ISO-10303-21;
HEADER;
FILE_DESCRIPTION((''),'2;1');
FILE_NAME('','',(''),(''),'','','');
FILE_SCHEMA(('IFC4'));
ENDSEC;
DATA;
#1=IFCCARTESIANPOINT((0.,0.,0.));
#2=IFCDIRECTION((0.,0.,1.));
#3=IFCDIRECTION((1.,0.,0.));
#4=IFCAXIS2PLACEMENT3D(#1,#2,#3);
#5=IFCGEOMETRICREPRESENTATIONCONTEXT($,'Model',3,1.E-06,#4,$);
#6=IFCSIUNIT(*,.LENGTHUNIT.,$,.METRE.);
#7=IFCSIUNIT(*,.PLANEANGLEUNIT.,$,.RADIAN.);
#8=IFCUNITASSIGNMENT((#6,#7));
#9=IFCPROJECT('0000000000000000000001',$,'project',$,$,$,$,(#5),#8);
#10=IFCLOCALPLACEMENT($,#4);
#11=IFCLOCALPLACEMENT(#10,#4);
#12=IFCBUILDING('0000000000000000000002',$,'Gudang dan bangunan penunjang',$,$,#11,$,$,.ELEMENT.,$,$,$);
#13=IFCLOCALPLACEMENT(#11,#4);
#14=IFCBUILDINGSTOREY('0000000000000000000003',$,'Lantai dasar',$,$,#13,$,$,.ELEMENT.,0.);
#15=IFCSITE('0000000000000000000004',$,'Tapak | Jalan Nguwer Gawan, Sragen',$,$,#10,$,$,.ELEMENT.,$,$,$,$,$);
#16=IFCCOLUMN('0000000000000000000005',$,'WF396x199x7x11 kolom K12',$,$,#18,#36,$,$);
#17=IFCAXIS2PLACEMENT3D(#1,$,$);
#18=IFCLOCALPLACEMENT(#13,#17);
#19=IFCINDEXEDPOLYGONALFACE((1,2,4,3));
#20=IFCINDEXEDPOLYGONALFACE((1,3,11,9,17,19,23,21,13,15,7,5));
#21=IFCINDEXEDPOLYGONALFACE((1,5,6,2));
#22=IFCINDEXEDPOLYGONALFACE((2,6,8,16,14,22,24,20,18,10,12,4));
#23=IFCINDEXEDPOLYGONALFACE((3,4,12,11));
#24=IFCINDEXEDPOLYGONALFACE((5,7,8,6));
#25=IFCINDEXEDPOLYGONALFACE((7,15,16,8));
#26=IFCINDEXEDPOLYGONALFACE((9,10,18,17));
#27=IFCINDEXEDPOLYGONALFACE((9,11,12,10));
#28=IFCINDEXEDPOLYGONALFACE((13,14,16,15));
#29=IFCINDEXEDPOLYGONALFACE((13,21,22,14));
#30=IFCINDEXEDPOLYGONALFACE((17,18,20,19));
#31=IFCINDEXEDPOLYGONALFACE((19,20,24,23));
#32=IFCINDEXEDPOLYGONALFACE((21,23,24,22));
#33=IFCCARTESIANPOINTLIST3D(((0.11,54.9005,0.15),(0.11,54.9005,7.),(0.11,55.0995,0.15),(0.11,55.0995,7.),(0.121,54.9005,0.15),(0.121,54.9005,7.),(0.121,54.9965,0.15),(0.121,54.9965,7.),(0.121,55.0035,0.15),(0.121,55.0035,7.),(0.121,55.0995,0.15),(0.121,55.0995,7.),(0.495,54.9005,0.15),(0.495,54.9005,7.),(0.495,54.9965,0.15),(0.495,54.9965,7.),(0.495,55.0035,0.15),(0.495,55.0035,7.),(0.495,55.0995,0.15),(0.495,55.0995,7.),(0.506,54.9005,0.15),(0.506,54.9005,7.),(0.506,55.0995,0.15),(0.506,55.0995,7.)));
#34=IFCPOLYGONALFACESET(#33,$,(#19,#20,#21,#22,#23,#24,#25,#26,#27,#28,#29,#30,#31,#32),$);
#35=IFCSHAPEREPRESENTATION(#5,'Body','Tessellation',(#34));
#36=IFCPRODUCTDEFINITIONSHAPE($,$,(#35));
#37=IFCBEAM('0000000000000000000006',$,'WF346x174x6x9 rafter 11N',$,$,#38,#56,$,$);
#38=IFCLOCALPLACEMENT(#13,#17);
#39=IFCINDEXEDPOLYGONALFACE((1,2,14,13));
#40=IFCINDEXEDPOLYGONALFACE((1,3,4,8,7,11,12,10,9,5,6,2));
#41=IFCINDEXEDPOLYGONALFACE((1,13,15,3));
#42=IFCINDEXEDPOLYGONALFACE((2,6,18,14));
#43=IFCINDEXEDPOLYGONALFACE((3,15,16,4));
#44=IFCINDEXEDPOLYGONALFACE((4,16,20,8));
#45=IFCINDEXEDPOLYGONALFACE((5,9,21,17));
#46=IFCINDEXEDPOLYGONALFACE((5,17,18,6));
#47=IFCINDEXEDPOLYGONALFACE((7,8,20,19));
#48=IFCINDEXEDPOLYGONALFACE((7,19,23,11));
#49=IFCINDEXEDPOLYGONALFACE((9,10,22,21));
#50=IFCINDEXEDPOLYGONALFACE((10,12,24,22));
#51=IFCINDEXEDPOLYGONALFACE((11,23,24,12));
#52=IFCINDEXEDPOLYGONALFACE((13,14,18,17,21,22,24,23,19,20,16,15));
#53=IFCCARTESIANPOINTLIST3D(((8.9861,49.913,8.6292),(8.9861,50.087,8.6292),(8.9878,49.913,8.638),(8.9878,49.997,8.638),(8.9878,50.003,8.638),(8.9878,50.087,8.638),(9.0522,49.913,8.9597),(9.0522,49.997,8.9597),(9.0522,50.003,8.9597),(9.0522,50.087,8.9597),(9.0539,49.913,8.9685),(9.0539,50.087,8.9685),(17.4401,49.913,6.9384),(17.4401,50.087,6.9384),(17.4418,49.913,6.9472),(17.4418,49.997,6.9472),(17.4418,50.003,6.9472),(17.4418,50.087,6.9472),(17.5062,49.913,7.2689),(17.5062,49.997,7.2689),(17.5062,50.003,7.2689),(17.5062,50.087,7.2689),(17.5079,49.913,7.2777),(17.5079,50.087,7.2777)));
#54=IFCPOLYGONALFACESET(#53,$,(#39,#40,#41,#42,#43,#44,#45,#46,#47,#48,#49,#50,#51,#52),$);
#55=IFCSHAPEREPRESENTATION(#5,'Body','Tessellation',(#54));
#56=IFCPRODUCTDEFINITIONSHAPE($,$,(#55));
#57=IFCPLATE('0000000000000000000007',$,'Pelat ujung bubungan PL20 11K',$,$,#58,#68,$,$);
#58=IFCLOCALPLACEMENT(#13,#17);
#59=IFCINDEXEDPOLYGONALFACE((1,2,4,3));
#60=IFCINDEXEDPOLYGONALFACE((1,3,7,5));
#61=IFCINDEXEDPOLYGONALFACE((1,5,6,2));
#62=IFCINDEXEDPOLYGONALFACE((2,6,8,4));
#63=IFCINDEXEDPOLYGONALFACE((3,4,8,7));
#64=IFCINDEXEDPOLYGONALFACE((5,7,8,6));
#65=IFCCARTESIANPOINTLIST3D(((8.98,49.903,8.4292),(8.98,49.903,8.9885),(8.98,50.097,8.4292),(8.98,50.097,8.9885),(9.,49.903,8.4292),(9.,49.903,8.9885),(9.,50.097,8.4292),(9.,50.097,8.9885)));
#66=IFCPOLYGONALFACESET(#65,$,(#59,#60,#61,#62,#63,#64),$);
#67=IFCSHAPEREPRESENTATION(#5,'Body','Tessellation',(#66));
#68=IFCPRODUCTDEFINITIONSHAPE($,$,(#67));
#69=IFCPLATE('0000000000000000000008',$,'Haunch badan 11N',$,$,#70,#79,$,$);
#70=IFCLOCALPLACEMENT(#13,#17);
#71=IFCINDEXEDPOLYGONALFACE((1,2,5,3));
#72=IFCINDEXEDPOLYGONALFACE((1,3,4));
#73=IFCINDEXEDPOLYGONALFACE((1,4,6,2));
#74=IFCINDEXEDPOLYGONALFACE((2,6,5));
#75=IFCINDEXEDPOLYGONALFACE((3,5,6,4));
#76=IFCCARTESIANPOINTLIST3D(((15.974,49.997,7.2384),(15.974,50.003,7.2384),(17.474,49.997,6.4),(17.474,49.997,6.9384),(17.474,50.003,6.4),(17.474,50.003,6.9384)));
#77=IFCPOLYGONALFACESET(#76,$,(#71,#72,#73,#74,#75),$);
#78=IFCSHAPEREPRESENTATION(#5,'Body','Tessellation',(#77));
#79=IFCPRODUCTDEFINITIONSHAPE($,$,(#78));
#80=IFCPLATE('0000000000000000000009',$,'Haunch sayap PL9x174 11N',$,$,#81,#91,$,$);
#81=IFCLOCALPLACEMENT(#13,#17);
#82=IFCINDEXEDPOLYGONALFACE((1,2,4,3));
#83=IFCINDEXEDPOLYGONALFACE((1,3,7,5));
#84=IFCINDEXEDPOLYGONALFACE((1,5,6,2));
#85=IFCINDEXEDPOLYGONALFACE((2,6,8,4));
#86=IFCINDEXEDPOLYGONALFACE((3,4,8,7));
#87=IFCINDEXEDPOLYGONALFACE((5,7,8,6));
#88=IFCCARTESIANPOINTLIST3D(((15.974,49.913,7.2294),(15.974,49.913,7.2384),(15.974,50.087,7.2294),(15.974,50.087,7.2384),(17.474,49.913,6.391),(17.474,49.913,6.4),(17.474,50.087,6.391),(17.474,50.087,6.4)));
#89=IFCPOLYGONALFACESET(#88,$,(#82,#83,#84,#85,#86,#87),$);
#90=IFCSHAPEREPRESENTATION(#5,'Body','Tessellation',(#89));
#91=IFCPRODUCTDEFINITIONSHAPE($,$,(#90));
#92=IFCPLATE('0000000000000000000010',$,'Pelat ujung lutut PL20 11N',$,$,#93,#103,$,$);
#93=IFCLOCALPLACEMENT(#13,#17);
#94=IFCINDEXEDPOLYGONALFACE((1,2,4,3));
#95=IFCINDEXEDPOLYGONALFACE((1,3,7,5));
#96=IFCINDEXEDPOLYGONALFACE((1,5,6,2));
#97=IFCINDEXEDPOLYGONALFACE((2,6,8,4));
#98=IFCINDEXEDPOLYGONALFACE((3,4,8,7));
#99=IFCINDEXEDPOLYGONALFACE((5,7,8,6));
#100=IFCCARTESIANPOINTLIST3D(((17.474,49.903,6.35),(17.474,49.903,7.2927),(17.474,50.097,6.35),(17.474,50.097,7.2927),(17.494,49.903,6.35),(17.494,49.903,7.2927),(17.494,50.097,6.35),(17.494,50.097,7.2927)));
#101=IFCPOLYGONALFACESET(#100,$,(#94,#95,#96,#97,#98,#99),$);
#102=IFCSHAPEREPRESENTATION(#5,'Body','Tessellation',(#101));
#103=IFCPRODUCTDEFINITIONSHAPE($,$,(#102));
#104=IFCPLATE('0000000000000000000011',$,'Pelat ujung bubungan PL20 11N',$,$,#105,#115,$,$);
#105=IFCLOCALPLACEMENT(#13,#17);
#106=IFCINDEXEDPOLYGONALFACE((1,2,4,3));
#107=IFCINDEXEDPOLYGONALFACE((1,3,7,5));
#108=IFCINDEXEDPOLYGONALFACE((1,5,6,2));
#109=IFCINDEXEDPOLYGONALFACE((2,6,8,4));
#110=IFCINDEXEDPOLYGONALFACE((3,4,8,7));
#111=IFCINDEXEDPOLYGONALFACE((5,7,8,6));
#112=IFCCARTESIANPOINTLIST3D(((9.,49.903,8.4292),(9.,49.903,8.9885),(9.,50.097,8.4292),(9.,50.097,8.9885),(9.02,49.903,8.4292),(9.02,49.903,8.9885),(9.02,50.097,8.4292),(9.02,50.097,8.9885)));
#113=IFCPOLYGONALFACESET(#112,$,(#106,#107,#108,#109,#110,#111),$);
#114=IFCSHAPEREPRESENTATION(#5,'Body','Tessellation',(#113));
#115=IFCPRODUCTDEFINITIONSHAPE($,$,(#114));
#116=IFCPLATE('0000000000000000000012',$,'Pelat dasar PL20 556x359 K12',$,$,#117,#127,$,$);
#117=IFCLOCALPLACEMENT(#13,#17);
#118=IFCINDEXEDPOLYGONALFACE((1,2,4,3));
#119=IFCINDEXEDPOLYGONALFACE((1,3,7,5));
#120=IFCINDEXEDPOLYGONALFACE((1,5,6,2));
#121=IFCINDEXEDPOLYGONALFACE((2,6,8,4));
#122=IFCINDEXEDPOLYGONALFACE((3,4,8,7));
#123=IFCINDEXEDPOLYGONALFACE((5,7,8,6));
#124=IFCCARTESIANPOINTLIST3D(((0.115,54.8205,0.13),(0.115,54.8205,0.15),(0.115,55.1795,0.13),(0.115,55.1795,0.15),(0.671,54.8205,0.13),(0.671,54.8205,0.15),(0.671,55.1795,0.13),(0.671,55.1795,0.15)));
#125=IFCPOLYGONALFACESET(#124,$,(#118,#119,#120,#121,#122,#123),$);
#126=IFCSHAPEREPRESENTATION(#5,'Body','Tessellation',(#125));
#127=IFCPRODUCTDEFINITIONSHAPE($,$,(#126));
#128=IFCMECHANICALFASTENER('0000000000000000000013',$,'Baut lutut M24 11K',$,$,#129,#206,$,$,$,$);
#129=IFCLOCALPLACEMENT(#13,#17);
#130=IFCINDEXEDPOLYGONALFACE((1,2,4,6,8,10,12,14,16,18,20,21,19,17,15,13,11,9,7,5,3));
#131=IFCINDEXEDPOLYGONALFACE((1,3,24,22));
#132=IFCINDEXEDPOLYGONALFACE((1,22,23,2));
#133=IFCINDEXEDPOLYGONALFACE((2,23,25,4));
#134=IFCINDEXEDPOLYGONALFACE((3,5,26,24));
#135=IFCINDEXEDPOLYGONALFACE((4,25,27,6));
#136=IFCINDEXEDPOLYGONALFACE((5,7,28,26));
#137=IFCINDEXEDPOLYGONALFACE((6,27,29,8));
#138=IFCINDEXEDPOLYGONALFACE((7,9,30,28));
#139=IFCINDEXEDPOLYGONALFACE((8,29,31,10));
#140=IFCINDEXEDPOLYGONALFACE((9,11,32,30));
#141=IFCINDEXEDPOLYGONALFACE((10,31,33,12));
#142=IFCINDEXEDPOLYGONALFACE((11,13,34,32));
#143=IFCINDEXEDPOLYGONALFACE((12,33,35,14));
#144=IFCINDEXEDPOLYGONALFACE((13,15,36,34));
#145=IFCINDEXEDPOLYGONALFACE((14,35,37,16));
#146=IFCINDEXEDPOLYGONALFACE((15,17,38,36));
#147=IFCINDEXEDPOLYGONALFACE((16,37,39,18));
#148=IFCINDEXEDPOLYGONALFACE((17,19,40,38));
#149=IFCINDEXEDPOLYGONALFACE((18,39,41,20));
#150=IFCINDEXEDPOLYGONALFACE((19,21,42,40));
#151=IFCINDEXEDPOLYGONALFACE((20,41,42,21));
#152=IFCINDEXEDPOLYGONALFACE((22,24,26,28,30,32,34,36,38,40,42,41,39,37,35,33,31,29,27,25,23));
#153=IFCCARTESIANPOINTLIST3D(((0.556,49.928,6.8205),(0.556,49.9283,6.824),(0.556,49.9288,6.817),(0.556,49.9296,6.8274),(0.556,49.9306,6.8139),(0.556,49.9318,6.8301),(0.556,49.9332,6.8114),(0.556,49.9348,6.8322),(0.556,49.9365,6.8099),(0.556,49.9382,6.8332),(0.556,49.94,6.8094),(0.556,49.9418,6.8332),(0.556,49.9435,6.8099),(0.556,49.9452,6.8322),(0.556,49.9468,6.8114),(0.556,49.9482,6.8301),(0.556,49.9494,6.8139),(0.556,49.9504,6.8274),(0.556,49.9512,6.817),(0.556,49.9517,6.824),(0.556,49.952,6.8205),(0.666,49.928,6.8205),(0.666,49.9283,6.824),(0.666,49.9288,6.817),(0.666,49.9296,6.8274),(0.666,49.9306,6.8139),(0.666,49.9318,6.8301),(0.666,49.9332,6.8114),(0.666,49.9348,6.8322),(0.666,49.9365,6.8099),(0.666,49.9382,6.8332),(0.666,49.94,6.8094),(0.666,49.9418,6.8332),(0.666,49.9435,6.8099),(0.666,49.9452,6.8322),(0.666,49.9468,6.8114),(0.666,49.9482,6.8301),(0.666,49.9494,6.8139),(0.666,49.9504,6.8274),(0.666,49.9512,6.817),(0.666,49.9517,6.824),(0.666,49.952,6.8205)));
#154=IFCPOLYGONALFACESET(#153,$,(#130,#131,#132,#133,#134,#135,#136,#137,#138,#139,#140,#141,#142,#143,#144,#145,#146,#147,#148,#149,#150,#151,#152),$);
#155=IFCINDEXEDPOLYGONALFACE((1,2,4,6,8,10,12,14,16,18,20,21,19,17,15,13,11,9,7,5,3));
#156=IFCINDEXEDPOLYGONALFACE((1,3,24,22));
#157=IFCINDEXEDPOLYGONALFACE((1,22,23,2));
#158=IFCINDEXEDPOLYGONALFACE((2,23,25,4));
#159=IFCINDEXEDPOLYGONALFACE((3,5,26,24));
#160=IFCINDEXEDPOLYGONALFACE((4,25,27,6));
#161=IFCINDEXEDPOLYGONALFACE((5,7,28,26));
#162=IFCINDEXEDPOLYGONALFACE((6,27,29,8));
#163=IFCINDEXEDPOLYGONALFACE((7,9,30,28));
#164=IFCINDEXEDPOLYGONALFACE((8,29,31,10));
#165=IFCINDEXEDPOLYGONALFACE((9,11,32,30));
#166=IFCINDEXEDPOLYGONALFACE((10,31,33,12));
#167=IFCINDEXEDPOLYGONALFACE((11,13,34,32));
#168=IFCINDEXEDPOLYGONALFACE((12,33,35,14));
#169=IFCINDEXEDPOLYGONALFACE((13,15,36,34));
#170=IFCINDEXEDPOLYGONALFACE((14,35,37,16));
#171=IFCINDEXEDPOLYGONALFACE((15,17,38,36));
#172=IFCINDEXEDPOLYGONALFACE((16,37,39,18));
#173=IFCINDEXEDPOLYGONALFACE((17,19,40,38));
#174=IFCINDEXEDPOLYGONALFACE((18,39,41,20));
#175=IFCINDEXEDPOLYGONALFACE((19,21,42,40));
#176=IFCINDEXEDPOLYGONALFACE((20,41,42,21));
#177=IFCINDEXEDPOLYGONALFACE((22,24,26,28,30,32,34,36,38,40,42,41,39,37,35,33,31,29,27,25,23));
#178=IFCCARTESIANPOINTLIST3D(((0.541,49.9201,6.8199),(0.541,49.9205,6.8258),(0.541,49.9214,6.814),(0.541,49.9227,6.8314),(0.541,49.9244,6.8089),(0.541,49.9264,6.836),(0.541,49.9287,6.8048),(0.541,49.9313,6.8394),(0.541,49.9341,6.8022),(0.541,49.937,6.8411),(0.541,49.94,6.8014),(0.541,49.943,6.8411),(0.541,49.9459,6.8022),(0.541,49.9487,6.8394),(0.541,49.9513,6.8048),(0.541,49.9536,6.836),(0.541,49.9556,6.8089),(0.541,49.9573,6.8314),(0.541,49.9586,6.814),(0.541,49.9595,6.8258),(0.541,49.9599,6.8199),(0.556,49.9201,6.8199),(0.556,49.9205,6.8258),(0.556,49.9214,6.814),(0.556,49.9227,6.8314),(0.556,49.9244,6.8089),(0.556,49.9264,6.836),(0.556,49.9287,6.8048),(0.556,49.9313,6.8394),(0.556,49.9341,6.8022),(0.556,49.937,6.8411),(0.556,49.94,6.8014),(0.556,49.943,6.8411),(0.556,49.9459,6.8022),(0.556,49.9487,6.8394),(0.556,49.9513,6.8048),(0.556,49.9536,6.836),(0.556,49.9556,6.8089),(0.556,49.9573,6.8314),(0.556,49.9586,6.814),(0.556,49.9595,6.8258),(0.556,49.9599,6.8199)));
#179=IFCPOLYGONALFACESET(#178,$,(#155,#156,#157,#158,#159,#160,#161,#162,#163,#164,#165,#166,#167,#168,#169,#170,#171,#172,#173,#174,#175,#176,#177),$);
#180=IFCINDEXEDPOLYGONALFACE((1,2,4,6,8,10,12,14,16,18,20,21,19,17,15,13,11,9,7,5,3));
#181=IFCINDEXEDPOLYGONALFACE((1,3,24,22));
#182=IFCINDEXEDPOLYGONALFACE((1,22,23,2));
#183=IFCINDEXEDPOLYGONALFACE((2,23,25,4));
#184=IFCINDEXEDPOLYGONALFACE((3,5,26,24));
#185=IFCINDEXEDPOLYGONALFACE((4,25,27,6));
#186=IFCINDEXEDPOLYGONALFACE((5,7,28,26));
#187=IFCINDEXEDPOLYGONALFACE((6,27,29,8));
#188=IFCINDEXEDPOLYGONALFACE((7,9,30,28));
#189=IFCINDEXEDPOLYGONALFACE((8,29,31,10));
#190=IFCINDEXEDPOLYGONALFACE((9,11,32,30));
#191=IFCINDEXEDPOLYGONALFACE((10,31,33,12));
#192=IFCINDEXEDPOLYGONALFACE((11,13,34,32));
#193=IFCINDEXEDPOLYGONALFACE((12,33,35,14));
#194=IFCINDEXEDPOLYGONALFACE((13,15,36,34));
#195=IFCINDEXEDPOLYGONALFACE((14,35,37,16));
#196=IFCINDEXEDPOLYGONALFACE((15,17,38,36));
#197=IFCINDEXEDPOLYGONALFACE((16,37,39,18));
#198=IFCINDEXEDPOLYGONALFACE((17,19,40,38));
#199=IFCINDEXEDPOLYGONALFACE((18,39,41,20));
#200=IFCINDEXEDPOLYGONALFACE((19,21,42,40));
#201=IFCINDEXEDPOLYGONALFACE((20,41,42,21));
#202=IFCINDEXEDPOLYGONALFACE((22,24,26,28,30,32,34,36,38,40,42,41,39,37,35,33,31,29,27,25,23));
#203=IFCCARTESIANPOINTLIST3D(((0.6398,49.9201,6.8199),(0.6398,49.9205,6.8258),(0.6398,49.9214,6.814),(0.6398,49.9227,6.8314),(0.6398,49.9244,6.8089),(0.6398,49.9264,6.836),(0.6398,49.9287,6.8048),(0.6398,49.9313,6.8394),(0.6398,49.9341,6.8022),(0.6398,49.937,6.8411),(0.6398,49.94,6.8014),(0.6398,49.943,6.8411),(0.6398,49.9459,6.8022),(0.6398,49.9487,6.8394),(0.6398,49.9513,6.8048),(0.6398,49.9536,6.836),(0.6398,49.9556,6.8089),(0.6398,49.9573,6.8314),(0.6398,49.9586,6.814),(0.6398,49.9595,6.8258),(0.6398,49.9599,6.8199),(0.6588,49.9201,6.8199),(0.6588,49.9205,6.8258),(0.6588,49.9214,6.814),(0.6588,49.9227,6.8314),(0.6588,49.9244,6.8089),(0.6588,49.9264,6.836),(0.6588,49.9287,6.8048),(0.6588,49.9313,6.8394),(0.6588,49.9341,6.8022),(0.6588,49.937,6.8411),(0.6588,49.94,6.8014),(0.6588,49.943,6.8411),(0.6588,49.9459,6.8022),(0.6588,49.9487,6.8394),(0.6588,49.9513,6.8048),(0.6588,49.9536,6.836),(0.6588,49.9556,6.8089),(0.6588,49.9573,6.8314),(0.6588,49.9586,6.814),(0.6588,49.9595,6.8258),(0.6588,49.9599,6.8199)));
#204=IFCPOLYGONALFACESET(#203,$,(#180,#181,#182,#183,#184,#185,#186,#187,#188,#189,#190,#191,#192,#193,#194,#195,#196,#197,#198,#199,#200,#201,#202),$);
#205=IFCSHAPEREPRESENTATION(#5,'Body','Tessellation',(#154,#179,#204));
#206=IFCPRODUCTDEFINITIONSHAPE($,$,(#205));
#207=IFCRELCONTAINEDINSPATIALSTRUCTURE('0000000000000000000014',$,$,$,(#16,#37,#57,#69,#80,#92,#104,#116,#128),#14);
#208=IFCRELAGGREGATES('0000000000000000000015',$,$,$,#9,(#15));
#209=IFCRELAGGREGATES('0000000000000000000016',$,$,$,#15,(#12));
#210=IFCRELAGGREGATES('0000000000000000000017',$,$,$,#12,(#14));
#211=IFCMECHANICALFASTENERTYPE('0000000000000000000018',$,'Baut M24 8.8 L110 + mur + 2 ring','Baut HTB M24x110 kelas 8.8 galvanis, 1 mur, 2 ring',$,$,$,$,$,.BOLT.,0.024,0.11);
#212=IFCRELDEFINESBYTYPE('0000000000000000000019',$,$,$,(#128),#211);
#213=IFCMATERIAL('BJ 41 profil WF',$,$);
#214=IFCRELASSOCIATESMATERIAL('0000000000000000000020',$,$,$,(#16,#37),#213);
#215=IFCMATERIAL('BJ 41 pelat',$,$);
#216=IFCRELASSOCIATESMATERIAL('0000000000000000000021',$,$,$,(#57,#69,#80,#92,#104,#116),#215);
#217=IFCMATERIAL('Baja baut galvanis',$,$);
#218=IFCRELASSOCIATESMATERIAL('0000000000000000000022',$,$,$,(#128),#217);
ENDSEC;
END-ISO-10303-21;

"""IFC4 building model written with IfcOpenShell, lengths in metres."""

from ifc_helpers import new_model, si_unit, frame, origin_with_axes, place, context, project, spatial, polyline, rectangle, circle, i_section, outline, extrude, source, transform, mapped, material, type_object, type_shapes, element, save


model = new_model("IFC4")

# Units and contexts
model_context = context("Model", 3, precision=1e-06, world=origin_with_axes())
ifc_project = project(units=[si_unit("LENGTHUNIT", "METRE"), si_unit("PLANEANGLEUNIT", "RADIAN")], contexts=[model_context])

# Site, building, storey
site_placement = place(None, origin_with_axes())
site = spatial("IfcSite", under=ifc_project, at=site_placement, Name="Tapak | Jalan Nguwer Gawan, Sragen", CompositionType="ELEMENT")
building_placement = place(site_placement, origin_with_axes())
building = spatial("IfcBuilding", under=site, at=building_placement, Name="Gudang dan bangunan penunjang", CompositionType="ELEMENT")
storey_placement = place(building_placement, origin_with_axes())
storey = spatial("IfcBuildingStorey", under=building, at=storey_placement, Name="Lantai dasar", CompositionType="ELEMENT", Elevation=0.0)

# Column
ifc_material_1 = material(Name="BJ 41 profil WF")
placement = place(None, origin_with_axes())
element("IfcColumn", 1, at=placement, inside=storey, material=ifc_material_1, Name="WF396x199x7x11 kolom K12", context=model_context, shape_type="SweptSolid", body=[
    extrude(i_section(OverallWidth=0.199, OverallDepth=0.396, WebThickness=0.007, FlangeThickness=0.011), frame((0.308, 55.0, 0.15), z_axis=(0.0, 0.0, 1.0), x_axis=(0.0, 1.0, 0.0)), (0.0, 0.0, 1.0), 6.85),
])

# Beam
element("IfcBeam", 2, at=placement, inside=storey, material=ifc_material_1, Name="WF346x174x6x9 rafter 11N", context=model_context, shape_type="SweptSolid", body=[
    extrude(i_section(OverallWidth=0.174, OverallDepth=0.346, WebThickness=0.006, FlangeThickness=0.009), frame((9.02, 50.0, 8.7989), z_axis=(0.980581, 0.0, -0.196116), x_axis=(0.0, 1.0, 0.0)), (0.0, 0.0, 1.0), 8.6214),
])

# Plates
ifc_material_2 = material(Name="BJ 41 pelat")
element("IfcPlate", 3, at=placement, inside=storey, material=ifc_material_2, Name="Pelat ujung bubungan PL20 11K", context=model_context, shape_type="SweptSolid", body=[
    extrude(rectangle(XDim=0.02, YDim=0.194), frame((8.99, 50.0, 8.4292), z_axis=(0.0, 0.0, 1.0), x_axis=(1.0, 0.0, 0.0)), (0.0, 0.0, 1.0), 0.5593),
])
element("IfcPlate", 4, at=placement, inside=storey, material=ifc_material_2, Name="Haunch badan 11N", context=model_context, shape_type="SweptSolid", body=[
    extrude(outline(polyline([(17.474, -6.9384), (15.974, -7.2384), (17.474, -6.4), (17.474, -6.9384)])), frame((0.0, 49.997, 0.0), z_axis=(0.0, 1.0, 0.0), x_axis=(1.0, 0.0, 0.0)), (0.0, 0.0, 1.0), 0.006),
])
element("IfcPlate", 5, at=placement, inside=storey, material=ifc_material_2, Name="Haunch sayap PL9x174 11N", context=model_context, shape_type="SweptSolid", body=[
    extrude(outline(polyline([(17.474, -6.4), (15.974, -7.2384), (15.974, -7.2294), (17.474, -6.391), (17.474, -6.4)])), frame((0.0, 49.913, 0.0), z_axis=(0.0, 1.0, 0.0), x_axis=(1.0, 0.0, 0.0)), (0.0, 0.0, 1.0), 0.174),
])
element("IfcPlate", 6, at=placement, inside=storey, material=ifc_material_2, Name="Pelat ujung lutut PL20 11N", context=model_context, shape_type="SweptSolid", body=[
    extrude(rectangle(XDim=0.02, YDim=0.194), frame((17.484, 50.0, 6.35), z_axis=(0.0, 0.0, 1.0), x_axis=(1.0, 0.0, 0.0)), (0.0, 0.0, 1.0), 0.9427),
])
element("IfcPlate", 7, at=placement, inside=storey, material=ifc_material_2, Name="Pelat ujung bubungan PL20 11N", context=model_context, shape_type="SweptSolid", body=[
    extrude(rectangle(XDim=0.02, YDim=0.194), frame((9.01, 50.0, 8.4292), z_axis=(0.0, 0.0, 1.0), x_axis=(1.0, 0.0, 0.0)), (0.0, 0.0, 1.0), 0.5593),
])
element("IfcPlate", 8, at=placement, inside=storey, material=ifc_material_2, Name="Pelat dasar PL20 556x359 K12", context=model_context, shape_type="SweptSolid", body=[
    extrude(rectangle(XDim=0.556, YDim=0.359), frame((0.393, 55.0, 0.13), z_axis=(0.0, 0.0, 1.0), x_axis=(1.0, 0.0, 0.0)), (0.0, 0.0, 1.0), 0.02),
])

# Mechanical fastener
ifc_material_3 = material(Name="Baja baut galvanis")
mechanical_fastener_type_1 = type_object("IfcMechanicalFastenerType", Name="Baut M24 8.8 L110 + mur + 2 ring", Description="Baut HTB M24x110 kelas 8.8 galvanis, 1 mur, 2 ring", NominalDiameter=0.024, NominalLength=0.11, PredefinedType="BOLT")
shared_shape_1 = source(origin_with_axes(), model_context, "Body", "SweptSolid", [
    extrude(circle(Radius=0.012), origin_with_axes(), (0.0, 0.0, 1.0), 0.11),
    extrude(circle(Radius=0.02), frame((0.0, 0.0, -0.015), z_axis=(0.0, 0.0, 1.0), x_axis=(1.0, 0.0, 0.0)), (0.0, 0.0, 1.0), 0.015),
    extrude(circle(Radius=0.02), frame((0.0, 0.0, 0.0838), z_axis=(0.0, 0.0, 1.0), x_axis=(1.0, 0.0, 0.0)), (0.0, 0.0, 1.0), 0.019),
])
type_shapes(mechanical_fastener_type_1, [shared_shape_1])
element("IfcMechanicalFastener", 9, at=placement, inside=storey, type_object=mechanical_fastener_type_1, material=ifc_material_3, Name="Baut lutut M24 11K", context=model_context, shape_type="MappedRepresentation", body=[
    mapped(shared_shape_1, transform((0.556, 49.94, 6.8213), x_axis=(0.0, 0.0, -1.0), y_axis=(0.0, 1.0, 0.0), z_axis=(1.0, 0.0, 0.0), scale=1.0)),
])

save(model, "model.ifc")
